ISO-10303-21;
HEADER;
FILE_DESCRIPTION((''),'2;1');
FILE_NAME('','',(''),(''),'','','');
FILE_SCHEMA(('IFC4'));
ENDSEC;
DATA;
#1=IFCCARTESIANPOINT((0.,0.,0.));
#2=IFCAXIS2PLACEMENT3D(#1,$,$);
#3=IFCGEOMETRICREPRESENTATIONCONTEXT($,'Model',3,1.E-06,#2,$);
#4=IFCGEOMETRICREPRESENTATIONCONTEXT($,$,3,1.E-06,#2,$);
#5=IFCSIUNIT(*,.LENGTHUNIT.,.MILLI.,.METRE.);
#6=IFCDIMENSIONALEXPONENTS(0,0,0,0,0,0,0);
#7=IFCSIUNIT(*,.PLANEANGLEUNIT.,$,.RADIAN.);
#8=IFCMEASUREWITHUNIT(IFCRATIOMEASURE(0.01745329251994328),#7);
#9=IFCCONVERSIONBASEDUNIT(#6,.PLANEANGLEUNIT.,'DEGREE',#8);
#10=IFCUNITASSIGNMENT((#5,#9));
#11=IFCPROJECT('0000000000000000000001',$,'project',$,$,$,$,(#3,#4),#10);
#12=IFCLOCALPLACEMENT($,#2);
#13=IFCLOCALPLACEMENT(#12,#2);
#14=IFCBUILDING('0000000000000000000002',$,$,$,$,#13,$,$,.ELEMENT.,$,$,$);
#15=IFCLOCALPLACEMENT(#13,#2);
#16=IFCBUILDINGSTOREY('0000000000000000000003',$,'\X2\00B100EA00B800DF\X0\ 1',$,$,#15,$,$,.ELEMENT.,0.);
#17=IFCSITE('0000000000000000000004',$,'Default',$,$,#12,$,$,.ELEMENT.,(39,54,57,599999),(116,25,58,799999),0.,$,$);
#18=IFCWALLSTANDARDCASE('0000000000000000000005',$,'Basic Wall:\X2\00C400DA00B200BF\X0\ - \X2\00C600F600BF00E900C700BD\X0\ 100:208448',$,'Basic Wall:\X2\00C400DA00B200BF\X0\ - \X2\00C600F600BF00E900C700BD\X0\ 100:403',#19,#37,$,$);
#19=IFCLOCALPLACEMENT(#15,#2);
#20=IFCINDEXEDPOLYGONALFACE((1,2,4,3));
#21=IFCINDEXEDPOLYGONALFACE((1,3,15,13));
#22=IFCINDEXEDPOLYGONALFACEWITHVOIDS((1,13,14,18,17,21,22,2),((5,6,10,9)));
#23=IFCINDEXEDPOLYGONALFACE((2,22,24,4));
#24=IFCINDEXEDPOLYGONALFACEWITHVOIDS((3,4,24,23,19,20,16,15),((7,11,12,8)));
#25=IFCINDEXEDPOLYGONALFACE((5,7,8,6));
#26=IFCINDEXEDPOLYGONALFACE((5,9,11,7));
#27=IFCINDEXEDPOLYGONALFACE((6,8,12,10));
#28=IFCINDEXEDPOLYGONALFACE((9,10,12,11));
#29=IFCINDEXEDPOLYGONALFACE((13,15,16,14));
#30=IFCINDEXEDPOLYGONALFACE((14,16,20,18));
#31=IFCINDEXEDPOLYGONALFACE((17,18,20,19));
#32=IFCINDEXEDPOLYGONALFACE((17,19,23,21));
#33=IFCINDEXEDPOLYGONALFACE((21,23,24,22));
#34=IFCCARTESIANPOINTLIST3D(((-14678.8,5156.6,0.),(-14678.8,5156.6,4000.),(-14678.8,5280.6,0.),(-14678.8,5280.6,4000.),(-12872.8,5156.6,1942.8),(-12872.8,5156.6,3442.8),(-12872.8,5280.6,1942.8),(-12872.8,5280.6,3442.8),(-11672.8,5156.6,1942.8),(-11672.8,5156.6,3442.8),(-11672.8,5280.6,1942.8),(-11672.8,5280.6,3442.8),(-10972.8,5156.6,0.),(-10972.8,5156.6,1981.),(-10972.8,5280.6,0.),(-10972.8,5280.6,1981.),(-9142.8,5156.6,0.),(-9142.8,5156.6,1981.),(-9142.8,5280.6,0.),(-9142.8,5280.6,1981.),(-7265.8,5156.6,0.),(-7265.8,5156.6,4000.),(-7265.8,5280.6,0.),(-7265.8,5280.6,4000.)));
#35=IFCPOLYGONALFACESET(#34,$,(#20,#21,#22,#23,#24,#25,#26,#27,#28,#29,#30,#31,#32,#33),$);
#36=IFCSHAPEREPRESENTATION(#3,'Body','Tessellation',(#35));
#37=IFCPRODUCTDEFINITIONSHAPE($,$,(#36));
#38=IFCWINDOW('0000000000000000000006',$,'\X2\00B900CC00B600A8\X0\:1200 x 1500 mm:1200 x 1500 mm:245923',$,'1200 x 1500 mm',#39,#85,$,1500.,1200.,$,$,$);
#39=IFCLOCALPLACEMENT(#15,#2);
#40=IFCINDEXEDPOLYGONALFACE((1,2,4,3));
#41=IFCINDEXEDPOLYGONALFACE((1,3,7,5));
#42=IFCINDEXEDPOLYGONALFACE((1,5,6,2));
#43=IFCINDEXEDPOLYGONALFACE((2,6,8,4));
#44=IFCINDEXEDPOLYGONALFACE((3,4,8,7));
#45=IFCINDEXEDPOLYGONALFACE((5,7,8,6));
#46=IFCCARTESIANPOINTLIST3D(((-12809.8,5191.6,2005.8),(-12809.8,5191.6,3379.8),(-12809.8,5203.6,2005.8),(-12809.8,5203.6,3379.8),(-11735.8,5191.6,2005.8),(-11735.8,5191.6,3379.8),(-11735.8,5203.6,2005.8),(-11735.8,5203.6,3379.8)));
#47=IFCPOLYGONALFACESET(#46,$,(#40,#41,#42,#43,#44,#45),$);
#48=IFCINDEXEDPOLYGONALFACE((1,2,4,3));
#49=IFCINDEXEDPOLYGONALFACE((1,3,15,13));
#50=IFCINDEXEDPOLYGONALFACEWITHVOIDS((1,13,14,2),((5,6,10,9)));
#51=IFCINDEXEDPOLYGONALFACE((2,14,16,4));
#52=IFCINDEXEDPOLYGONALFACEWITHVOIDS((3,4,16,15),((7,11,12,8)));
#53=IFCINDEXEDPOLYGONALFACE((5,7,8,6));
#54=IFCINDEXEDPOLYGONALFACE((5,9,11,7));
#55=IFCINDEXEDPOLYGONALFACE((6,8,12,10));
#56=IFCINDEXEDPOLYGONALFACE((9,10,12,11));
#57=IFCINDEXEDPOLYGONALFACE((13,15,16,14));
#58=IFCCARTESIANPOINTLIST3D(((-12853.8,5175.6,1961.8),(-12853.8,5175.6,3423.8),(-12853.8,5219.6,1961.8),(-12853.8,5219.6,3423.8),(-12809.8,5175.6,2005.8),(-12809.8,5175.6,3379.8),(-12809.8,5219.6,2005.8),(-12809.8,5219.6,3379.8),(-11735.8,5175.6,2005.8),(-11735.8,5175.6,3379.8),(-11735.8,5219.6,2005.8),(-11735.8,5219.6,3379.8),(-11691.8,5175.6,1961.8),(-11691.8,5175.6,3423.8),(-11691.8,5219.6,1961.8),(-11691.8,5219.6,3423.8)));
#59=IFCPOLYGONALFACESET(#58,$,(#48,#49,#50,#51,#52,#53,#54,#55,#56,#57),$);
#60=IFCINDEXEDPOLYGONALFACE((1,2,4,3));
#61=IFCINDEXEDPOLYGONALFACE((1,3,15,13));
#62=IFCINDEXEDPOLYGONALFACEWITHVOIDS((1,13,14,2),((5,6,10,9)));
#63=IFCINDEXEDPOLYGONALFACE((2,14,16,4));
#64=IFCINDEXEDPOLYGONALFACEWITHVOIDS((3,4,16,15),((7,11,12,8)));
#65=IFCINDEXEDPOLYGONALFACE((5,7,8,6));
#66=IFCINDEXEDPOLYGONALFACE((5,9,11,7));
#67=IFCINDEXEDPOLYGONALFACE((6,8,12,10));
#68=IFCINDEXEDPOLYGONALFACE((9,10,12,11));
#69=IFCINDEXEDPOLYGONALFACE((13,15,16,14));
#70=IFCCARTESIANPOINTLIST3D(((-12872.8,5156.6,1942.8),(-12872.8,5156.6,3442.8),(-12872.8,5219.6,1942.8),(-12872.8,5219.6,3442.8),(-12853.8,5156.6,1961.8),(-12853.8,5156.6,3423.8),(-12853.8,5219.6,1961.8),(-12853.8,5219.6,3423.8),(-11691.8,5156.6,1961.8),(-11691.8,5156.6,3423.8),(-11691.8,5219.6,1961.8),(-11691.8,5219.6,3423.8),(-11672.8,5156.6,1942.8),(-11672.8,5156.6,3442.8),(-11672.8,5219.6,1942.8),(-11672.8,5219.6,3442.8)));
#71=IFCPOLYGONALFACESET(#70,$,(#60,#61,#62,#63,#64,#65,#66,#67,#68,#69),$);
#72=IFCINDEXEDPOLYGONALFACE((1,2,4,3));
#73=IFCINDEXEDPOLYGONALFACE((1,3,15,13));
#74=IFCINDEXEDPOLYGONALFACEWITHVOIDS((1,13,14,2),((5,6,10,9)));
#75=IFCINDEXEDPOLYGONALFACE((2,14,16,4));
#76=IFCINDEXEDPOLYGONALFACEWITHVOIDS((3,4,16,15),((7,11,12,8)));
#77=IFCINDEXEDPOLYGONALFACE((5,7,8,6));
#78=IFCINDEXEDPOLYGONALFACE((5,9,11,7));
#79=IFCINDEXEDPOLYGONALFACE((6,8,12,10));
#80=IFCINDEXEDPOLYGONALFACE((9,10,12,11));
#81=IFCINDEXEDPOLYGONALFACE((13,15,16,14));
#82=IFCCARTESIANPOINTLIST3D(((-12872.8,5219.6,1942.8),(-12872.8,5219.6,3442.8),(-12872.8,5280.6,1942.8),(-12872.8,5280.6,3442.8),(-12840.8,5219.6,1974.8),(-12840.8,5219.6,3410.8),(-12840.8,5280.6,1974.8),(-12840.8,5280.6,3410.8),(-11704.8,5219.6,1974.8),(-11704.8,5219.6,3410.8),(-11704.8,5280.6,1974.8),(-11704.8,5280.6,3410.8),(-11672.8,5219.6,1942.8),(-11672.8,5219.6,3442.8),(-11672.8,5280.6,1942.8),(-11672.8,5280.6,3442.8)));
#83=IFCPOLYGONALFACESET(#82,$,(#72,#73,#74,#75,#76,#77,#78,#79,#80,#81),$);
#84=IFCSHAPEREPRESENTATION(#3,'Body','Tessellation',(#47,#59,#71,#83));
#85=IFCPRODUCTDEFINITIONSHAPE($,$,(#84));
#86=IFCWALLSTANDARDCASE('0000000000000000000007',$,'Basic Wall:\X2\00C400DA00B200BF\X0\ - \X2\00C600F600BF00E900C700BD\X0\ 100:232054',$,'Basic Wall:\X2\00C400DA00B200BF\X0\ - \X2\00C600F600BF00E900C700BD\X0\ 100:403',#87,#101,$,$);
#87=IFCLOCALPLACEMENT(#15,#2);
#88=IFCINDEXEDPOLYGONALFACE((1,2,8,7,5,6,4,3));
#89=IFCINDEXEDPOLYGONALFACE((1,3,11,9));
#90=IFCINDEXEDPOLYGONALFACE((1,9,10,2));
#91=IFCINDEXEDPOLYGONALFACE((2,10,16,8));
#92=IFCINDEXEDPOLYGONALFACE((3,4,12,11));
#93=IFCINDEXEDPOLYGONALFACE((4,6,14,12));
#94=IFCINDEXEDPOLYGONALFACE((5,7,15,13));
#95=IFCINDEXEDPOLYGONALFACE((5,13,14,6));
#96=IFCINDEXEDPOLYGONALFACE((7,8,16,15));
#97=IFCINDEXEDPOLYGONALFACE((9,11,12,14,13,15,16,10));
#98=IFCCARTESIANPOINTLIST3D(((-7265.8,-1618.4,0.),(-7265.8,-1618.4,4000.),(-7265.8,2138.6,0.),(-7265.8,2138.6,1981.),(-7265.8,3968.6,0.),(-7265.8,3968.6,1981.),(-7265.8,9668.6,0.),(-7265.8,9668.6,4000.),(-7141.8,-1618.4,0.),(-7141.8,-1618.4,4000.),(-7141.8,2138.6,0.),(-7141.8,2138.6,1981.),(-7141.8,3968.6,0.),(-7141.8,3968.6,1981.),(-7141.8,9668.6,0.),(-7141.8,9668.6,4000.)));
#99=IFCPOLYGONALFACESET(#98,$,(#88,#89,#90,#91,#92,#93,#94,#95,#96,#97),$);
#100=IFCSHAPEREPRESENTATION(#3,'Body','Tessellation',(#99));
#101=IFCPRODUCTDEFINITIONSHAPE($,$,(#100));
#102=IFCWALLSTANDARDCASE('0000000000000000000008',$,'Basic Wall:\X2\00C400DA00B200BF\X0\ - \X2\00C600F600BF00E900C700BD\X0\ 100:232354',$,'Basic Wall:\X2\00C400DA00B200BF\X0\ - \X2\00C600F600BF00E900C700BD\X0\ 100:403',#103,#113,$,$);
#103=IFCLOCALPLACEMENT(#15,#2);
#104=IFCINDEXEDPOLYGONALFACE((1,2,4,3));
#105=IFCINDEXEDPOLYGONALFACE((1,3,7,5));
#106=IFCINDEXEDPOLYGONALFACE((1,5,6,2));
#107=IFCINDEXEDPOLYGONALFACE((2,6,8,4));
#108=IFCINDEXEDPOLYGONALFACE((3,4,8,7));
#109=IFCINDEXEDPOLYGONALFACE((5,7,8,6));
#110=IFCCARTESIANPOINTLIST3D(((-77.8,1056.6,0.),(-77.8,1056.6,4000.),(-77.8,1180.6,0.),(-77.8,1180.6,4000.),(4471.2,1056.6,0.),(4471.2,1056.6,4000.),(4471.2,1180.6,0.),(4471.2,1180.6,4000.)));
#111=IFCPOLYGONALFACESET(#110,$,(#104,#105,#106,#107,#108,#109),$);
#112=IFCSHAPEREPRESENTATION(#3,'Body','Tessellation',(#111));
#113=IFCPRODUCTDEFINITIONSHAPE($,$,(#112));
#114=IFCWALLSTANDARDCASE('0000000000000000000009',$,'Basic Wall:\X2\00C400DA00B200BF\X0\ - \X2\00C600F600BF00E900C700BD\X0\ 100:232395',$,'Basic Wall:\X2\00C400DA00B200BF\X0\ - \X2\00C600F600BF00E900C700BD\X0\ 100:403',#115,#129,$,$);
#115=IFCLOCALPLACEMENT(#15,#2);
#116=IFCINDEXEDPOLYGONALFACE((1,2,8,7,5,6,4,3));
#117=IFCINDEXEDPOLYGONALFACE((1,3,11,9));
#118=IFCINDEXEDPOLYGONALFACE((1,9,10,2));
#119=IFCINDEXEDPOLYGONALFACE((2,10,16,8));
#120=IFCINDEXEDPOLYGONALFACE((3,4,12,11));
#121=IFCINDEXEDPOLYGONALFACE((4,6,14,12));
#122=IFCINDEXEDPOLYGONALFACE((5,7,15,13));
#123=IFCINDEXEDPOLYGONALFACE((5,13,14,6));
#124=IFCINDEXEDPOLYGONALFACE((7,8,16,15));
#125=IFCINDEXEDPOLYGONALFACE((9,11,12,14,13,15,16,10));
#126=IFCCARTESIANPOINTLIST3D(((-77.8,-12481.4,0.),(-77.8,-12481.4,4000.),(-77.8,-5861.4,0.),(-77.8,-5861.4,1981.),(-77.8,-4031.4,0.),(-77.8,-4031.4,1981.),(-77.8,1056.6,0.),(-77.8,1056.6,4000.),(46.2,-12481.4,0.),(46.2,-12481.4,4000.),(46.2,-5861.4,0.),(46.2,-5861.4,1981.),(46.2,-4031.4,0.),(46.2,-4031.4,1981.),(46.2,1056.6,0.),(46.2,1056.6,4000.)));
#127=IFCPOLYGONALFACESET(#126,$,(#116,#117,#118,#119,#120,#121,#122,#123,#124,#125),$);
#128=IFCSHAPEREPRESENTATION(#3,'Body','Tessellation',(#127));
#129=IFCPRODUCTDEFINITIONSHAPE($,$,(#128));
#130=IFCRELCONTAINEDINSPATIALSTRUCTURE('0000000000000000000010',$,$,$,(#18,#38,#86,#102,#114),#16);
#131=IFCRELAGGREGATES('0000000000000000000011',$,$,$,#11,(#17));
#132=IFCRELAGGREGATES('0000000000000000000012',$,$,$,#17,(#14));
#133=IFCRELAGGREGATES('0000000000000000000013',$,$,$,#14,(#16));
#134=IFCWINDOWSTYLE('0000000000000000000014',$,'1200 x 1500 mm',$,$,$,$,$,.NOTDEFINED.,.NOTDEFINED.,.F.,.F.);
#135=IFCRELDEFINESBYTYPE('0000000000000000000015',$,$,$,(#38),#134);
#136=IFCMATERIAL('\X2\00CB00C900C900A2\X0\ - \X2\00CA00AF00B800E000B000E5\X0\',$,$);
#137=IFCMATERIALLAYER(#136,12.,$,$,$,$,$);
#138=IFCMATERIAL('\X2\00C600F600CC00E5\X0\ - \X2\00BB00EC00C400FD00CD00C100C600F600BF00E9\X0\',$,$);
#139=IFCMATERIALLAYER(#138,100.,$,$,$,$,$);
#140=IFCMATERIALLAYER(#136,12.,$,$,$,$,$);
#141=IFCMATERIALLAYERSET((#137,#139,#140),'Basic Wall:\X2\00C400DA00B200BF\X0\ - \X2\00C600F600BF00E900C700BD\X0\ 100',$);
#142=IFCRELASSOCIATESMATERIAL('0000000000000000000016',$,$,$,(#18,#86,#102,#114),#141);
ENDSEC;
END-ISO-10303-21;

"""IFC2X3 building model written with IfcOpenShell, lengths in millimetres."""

from ifc_helpers import new_model, entity, si_unit, converted_unit, frame, frame_2d, origin, origin_2d_with_axis, place, context, project, spatial, polyline, rectangle, outline, extrude, source, transform, mapped, material, layer, layer_set, layer_usage, type_object, type_shapes, element, fill, save


model = new_model("IFC2X3")

# Units and contexts
model_context = context("Model", 3, precision=1e-06, world=origin())
context_of_model = context(None, 3, precision=1e-06, world=origin())
ifc_project = project(units=[si_unit("LENGTHUNIT", "METRE", prefix="MILLI"), converted_unit("PLANEANGLEUNIT", "DEGREE", entity("IfcRatioMeasure", 0.01745329251994328), si_unit("PLANEANGLEUNIT", "RADIAN"), dimensions=[0, 0, 0, 0, 0, 0, 0])], contexts=[model_context, context_of_model])

# Site, building, storey
site_placement = place(None, origin())
site = spatial("IfcSite", under=ifc_project, at=site_placement, Name="Default", CompositionType="ELEMENT", RefLatitude=(39, 54, 57, 599999), RefLongitude=(116, 25, 58, 799999), RefElevation=0.0)
building_placement = place(site_placement, origin())
building = spatial("IfcBuilding", under=site, at=building_placement, CompositionType="ELEMENT")
storey_placement = place(building_placement, origin())
storey = spatial("IfcBuildingStorey", under=building, at=storey_placement, Name="±ê¸ß 1", CompositionType="ELEMENT", Elevation=0.0)

# Shared definitions
ifc_material_1 = material(Name="ËÉÉ¢ - Ê¯¸à°å")

# Shared definitions
ifc_layer_1 = layer(ifc_material_1, 12.0)
ifc_material_2 = material(Name="ÆöÌå - »ìÄýÍÁÆö¿é")
ifc_layer_2 = layer(ifc_material_2, 100.0)
ifc_layer_3 = layer(ifc_material_1, 12.0)
ifc_layer_set_1 = layer_set([ifc_layer_1, ifc_layer_2, ifc_layer_3], Name="Basic Wall:ÄÚ²¿ - Æö¿éÇ½ 100")

# Shared definitions
window_style_1 = type_object("IfcWindowStyle", Name="1200 x 1500 mm", ConstructionType="NOTDEFINED", OperationType="NOTDEFINED", ParameterTakesPrecedence=False, Sizeable=False)
shared_shape_1 = source(origin(), model_context, "Body", "SweptSolid", [
    extrude(rectangle(XDim=12.0, YDim=1074.0, at=origin_2d_with_axis()), frame((600.0, 83.0, 63.0), z_axis=(0.0, 0.0, 1.0), x_axis=(0.0, -1.0, 0.0)), (0.0, 0.0, 1.0), 1374.0),
    extrude(outline(polyline([(-581.0, -731.0), (581.0, -731.0), (581.0, 731.0), (-581.0, 731.0), (-581.0, -731.0)]), holes=[polyline([(-537.0, -687.0), (-537.0, 687.0), (537.0, 687.0), (537.0, -687.0), (-537.0, -687.0)])]), frame((600.0, 61.0, 750.0), z_axis=(0.0, 1.0, 0.0), x_axis=(1.0, 0.0, 0.0)), (0.0, 0.0, 1.0), 44.0),
    extrude(outline(polyline([(-600.0, -750.0), (600.0, -750.0), (600.0, 750.0), (-600.0, 750.0), (-600.0, -750.0)]), holes=[polyline([(-581.0, -731.0), (-581.0, 731.0), (581.0, 731.0), (581.0, -731.0), (-581.0, -731.0)])]), frame((600.0, 61.0, 750.0), z_axis=(0.0, 1.0, 0.0), x_axis=(1.0, 0.0, 0.0)), (0.0, 0.0, 1.0), 63.0),
    extrude(outline(polyline([(-600.0, -750.0), (600.0, -750.0), (600.0, 750.0), (-600.0, 750.0), (-600.0, -750.0)]), holes=[polyline([(-568.0, -718.0), (-568.0, 718.0), (568.0, 718.0), (568.0, -718.0), (-568.0, -718.0)])]), frame((600.0, 0.0, 750.0), z_axis=(0.0, 1.0, 0.0), x_axis=(1.0, 0.0, 0.0)), (0.0, 0.0, 1.0), 61.0),
])
type_shapes(window_style_1, [shared_shape_1])

# Wall, openings, window
ifc_layer_usage_1 = layer_usage(ifc_layer_set_1, "AXIS2", "NEGATIVE", 62.0)
wall_1_placement = place(storey_placement, frame((-14678.8, 5218.6, 0.0)))
wall_1 = element("IfcWallStandardCase", 1, at=wall_1_placement, inside=storey, material=ifc_layer_usage_1, Name="Basic Wall:ÄÚ²¿ - Æö¿éÇ½ 100:208448", ObjectType="Basic Wall:ÄÚ²¿ - Æö¿éÇ½ 100:403", context=model_context, shape_type="SweptSolid", body=[
    extrude(rectangle(XDim=7413.0, YDim=124.0, at=frame_2d((3706.5, 0.0), x_axis=(-1.0, 0.0))), origin(), (0.0, 0.0, 1.0), 4000.0),
])
opening_1_placement = place(wall_1_placement, frame((1806.0, -62.0, 1942.8)))
opening_1 = element("IfcOpeningElement", 2, at=opening_1_placement, cuts=wall_1, ObjectType="Opening", context=model_context, shape_type="SweptSolid", body=[
    extrude(rectangle(XDim=1500.0, YDim=1200.0, at=frame_2d((750.0, 600.0), x_axis=(1.0, 0.0))), frame((0.0, 0.0, 0.0), z_axis=(0.0, 1.0, 0.0), x_axis=(0.0, 0.0, 1.0)), (0.0, 0.0, 1.0), 124.0),
])
opening_2_placement = place(wall_1_placement, frame((5536.0, 62.0, 0.0)))
element("IfcOpeningElement", 3, at=opening_2_placement, cuts=wall_1, ObjectType="Opening", context=model_context, shape_type="SweptSolid", body=[
    extrude(rectangle(XDim=1981.0, YDim=1830.0, at=frame_2d((990.5, 915.0), x_axis=(1.0, 0.0))), frame((0.0, 0.0, 0.0), z_axis=(0.0, -1.0, 0.0), x_axis=(0.0, 0.0, 1.0)), (0.0, 0.0, 1.0), 124.0),
])
window_1_placement = place(opening_1_placement, frame((1200.0, 124.0, 0.0), z_axis=(0.0, 0.0, 1.0), x_axis=(-1.0, 0.0, 0.0)))
window_1 = element("IfcWindow", 4, at=window_1_placement, inside=storey, type_object=window_style_1, Name="¹Ì¶¨:1200 x 1500 mm:1200 x 1500 mm:245923", ObjectType="1200 x 1500 mm", OverallHeight=1500.0, OverallWidth=1200.0, context=model_context, shape_type="MappedRepresentation", body=[
    mapped(shared_shape_1, transform((0.0, 0.0, 0.0), scale=1.0)),
])
fill(opening_1, window_1)

# Wall, opening
ifc_layer_usage_2 = layer_usage(ifc_layer_set_1, "AXIS2", "NEGATIVE", 62.0)
wall_2_placement = place(storey_placement, frame((-7203.8, 9668.6, 0.0), z_axis=(0.0, 0.0, 1.0), x_axis=(0.0, -1.0, 0.0)))
wall_2 = element("IfcWallStandardCase", 5, at=wall_2_placement, inside=storey, material=ifc_layer_usage_2, Name="Basic Wall:ÄÚ²¿ - Æö¿éÇ½ 100:232054", ObjectType="Basic Wall:ÄÚ²¿ - Æö¿éÇ½ 100:403", context=model_context, shape_type="SweptSolid", body=[
    extrude(rectangle(XDim=11287.0, YDim=124.0, at=frame_2d((5643.5, 0.0), x_axis=(-1.0, 0.0))), origin(), (0.0, 0.0, 1.0), 4000.0),
])
opening_3_placement = place(wall_2_placement, frame((7530.0, 62.0, 0.0)))
element("IfcOpeningElement", 6, at=opening_3_placement, cuts=wall_2, ObjectType="Opening", context=model_context, shape_type="SweptSolid", body=[
    extrude(rectangle(XDim=1981.0, YDim=1830.0, at=frame_2d((990.5, 915.0), x_axis=(1.0, 0.0))), frame((0.0, 0.0, 0.0), z_axis=(0.0, -1.0, 0.0), x_axis=(0.0, 0.0, 1.0)), (0.0, 0.0, 1.0), 124.0),
])

# Wall
ifc_layer_usage_3 = layer_usage(ifc_layer_set_1, "AXIS2", "NEGATIVE", 62.0)
wall_3_placement = place(storey_placement, frame((4471.2, 1118.6, 0.0), z_axis=(0.0, 0.0, 1.0), x_axis=(-1.0, 0.0, 0.0)))
element("IfcWallStandardCase", 7, at=wall_3_placement, inside=storey, material=ifc_layer_usage_3, Name="Basic Wall:ÄÚ²¿ - Æö¿éÇ½ 100:232354", ObjectType="Basic Wall:ÄÚ²¿ - Æö¿éÇ½ 100:403", context=model_context, shape_type="SweptSolid", body=[
    extrude(rectangle(XDim=4549.0, YDim=124.0, at=frame_2d((2274.5, 0.0), x_axis=(-1.0, 0.0))), origin(), (0.0, 0.0, 1.0), 4000.0),
])

# Wall, opening
ifc_layer_usage_4 = layer_usage(ifc_layer_set_1, "AXIS2", "NEGATIVE", 62.0)
wall_4_placement = place(storey_placement, frame((-15.8, 1056.6, 0.0), z_axis=(0.0, 0.0, 1.0), x_axis=(0.0, -1.0, 0.0)))
wall_4 = element("IfcWallStandardCase", 8, at=wall_4_placement, inside=storey, material=ifc_layer_usage_4, Name="Basic Wall:ÄÚ²¿ - Æö¿éÇ½ 100:232395", ObjectType="Basic Wall:ÄÚ²¿ - Æö¿éÇ½ 100:403", context=model_context, shape_type="SweptSolid", body=[
    extrude(rectangle(XDim=13538.0, YDim=124.0, at=frame_2d((6769.0, 0.0), x_axis=(-1.0, 0.0))), origin(), (0.0, 0.0, 1.0), 4000.0),
])
opening_4_placement = place(wall_4_placement, frame((6918.0, 62.0, 0.0)))
element("IfcOpeningElement", 9, at=opening_4_placement, cuts=wall_4, ObjectType="Opening", context=model_context, shape_type="SweptSolid", body=[
    extrude(rectangle(XDim=1981.0, YDim=1830.0, at=frame_2d((990.5, 915.0), x_axis=(1.0, 0.0))), frame((0.0, 0.0, 0.0), z_axis=(0.0, -1.0, 0.0), x_axis=(0.0, 0.0, 1.0)), (0.0, 0.0, 1.0), 124.0),
])

save(model, "model.ifc")
